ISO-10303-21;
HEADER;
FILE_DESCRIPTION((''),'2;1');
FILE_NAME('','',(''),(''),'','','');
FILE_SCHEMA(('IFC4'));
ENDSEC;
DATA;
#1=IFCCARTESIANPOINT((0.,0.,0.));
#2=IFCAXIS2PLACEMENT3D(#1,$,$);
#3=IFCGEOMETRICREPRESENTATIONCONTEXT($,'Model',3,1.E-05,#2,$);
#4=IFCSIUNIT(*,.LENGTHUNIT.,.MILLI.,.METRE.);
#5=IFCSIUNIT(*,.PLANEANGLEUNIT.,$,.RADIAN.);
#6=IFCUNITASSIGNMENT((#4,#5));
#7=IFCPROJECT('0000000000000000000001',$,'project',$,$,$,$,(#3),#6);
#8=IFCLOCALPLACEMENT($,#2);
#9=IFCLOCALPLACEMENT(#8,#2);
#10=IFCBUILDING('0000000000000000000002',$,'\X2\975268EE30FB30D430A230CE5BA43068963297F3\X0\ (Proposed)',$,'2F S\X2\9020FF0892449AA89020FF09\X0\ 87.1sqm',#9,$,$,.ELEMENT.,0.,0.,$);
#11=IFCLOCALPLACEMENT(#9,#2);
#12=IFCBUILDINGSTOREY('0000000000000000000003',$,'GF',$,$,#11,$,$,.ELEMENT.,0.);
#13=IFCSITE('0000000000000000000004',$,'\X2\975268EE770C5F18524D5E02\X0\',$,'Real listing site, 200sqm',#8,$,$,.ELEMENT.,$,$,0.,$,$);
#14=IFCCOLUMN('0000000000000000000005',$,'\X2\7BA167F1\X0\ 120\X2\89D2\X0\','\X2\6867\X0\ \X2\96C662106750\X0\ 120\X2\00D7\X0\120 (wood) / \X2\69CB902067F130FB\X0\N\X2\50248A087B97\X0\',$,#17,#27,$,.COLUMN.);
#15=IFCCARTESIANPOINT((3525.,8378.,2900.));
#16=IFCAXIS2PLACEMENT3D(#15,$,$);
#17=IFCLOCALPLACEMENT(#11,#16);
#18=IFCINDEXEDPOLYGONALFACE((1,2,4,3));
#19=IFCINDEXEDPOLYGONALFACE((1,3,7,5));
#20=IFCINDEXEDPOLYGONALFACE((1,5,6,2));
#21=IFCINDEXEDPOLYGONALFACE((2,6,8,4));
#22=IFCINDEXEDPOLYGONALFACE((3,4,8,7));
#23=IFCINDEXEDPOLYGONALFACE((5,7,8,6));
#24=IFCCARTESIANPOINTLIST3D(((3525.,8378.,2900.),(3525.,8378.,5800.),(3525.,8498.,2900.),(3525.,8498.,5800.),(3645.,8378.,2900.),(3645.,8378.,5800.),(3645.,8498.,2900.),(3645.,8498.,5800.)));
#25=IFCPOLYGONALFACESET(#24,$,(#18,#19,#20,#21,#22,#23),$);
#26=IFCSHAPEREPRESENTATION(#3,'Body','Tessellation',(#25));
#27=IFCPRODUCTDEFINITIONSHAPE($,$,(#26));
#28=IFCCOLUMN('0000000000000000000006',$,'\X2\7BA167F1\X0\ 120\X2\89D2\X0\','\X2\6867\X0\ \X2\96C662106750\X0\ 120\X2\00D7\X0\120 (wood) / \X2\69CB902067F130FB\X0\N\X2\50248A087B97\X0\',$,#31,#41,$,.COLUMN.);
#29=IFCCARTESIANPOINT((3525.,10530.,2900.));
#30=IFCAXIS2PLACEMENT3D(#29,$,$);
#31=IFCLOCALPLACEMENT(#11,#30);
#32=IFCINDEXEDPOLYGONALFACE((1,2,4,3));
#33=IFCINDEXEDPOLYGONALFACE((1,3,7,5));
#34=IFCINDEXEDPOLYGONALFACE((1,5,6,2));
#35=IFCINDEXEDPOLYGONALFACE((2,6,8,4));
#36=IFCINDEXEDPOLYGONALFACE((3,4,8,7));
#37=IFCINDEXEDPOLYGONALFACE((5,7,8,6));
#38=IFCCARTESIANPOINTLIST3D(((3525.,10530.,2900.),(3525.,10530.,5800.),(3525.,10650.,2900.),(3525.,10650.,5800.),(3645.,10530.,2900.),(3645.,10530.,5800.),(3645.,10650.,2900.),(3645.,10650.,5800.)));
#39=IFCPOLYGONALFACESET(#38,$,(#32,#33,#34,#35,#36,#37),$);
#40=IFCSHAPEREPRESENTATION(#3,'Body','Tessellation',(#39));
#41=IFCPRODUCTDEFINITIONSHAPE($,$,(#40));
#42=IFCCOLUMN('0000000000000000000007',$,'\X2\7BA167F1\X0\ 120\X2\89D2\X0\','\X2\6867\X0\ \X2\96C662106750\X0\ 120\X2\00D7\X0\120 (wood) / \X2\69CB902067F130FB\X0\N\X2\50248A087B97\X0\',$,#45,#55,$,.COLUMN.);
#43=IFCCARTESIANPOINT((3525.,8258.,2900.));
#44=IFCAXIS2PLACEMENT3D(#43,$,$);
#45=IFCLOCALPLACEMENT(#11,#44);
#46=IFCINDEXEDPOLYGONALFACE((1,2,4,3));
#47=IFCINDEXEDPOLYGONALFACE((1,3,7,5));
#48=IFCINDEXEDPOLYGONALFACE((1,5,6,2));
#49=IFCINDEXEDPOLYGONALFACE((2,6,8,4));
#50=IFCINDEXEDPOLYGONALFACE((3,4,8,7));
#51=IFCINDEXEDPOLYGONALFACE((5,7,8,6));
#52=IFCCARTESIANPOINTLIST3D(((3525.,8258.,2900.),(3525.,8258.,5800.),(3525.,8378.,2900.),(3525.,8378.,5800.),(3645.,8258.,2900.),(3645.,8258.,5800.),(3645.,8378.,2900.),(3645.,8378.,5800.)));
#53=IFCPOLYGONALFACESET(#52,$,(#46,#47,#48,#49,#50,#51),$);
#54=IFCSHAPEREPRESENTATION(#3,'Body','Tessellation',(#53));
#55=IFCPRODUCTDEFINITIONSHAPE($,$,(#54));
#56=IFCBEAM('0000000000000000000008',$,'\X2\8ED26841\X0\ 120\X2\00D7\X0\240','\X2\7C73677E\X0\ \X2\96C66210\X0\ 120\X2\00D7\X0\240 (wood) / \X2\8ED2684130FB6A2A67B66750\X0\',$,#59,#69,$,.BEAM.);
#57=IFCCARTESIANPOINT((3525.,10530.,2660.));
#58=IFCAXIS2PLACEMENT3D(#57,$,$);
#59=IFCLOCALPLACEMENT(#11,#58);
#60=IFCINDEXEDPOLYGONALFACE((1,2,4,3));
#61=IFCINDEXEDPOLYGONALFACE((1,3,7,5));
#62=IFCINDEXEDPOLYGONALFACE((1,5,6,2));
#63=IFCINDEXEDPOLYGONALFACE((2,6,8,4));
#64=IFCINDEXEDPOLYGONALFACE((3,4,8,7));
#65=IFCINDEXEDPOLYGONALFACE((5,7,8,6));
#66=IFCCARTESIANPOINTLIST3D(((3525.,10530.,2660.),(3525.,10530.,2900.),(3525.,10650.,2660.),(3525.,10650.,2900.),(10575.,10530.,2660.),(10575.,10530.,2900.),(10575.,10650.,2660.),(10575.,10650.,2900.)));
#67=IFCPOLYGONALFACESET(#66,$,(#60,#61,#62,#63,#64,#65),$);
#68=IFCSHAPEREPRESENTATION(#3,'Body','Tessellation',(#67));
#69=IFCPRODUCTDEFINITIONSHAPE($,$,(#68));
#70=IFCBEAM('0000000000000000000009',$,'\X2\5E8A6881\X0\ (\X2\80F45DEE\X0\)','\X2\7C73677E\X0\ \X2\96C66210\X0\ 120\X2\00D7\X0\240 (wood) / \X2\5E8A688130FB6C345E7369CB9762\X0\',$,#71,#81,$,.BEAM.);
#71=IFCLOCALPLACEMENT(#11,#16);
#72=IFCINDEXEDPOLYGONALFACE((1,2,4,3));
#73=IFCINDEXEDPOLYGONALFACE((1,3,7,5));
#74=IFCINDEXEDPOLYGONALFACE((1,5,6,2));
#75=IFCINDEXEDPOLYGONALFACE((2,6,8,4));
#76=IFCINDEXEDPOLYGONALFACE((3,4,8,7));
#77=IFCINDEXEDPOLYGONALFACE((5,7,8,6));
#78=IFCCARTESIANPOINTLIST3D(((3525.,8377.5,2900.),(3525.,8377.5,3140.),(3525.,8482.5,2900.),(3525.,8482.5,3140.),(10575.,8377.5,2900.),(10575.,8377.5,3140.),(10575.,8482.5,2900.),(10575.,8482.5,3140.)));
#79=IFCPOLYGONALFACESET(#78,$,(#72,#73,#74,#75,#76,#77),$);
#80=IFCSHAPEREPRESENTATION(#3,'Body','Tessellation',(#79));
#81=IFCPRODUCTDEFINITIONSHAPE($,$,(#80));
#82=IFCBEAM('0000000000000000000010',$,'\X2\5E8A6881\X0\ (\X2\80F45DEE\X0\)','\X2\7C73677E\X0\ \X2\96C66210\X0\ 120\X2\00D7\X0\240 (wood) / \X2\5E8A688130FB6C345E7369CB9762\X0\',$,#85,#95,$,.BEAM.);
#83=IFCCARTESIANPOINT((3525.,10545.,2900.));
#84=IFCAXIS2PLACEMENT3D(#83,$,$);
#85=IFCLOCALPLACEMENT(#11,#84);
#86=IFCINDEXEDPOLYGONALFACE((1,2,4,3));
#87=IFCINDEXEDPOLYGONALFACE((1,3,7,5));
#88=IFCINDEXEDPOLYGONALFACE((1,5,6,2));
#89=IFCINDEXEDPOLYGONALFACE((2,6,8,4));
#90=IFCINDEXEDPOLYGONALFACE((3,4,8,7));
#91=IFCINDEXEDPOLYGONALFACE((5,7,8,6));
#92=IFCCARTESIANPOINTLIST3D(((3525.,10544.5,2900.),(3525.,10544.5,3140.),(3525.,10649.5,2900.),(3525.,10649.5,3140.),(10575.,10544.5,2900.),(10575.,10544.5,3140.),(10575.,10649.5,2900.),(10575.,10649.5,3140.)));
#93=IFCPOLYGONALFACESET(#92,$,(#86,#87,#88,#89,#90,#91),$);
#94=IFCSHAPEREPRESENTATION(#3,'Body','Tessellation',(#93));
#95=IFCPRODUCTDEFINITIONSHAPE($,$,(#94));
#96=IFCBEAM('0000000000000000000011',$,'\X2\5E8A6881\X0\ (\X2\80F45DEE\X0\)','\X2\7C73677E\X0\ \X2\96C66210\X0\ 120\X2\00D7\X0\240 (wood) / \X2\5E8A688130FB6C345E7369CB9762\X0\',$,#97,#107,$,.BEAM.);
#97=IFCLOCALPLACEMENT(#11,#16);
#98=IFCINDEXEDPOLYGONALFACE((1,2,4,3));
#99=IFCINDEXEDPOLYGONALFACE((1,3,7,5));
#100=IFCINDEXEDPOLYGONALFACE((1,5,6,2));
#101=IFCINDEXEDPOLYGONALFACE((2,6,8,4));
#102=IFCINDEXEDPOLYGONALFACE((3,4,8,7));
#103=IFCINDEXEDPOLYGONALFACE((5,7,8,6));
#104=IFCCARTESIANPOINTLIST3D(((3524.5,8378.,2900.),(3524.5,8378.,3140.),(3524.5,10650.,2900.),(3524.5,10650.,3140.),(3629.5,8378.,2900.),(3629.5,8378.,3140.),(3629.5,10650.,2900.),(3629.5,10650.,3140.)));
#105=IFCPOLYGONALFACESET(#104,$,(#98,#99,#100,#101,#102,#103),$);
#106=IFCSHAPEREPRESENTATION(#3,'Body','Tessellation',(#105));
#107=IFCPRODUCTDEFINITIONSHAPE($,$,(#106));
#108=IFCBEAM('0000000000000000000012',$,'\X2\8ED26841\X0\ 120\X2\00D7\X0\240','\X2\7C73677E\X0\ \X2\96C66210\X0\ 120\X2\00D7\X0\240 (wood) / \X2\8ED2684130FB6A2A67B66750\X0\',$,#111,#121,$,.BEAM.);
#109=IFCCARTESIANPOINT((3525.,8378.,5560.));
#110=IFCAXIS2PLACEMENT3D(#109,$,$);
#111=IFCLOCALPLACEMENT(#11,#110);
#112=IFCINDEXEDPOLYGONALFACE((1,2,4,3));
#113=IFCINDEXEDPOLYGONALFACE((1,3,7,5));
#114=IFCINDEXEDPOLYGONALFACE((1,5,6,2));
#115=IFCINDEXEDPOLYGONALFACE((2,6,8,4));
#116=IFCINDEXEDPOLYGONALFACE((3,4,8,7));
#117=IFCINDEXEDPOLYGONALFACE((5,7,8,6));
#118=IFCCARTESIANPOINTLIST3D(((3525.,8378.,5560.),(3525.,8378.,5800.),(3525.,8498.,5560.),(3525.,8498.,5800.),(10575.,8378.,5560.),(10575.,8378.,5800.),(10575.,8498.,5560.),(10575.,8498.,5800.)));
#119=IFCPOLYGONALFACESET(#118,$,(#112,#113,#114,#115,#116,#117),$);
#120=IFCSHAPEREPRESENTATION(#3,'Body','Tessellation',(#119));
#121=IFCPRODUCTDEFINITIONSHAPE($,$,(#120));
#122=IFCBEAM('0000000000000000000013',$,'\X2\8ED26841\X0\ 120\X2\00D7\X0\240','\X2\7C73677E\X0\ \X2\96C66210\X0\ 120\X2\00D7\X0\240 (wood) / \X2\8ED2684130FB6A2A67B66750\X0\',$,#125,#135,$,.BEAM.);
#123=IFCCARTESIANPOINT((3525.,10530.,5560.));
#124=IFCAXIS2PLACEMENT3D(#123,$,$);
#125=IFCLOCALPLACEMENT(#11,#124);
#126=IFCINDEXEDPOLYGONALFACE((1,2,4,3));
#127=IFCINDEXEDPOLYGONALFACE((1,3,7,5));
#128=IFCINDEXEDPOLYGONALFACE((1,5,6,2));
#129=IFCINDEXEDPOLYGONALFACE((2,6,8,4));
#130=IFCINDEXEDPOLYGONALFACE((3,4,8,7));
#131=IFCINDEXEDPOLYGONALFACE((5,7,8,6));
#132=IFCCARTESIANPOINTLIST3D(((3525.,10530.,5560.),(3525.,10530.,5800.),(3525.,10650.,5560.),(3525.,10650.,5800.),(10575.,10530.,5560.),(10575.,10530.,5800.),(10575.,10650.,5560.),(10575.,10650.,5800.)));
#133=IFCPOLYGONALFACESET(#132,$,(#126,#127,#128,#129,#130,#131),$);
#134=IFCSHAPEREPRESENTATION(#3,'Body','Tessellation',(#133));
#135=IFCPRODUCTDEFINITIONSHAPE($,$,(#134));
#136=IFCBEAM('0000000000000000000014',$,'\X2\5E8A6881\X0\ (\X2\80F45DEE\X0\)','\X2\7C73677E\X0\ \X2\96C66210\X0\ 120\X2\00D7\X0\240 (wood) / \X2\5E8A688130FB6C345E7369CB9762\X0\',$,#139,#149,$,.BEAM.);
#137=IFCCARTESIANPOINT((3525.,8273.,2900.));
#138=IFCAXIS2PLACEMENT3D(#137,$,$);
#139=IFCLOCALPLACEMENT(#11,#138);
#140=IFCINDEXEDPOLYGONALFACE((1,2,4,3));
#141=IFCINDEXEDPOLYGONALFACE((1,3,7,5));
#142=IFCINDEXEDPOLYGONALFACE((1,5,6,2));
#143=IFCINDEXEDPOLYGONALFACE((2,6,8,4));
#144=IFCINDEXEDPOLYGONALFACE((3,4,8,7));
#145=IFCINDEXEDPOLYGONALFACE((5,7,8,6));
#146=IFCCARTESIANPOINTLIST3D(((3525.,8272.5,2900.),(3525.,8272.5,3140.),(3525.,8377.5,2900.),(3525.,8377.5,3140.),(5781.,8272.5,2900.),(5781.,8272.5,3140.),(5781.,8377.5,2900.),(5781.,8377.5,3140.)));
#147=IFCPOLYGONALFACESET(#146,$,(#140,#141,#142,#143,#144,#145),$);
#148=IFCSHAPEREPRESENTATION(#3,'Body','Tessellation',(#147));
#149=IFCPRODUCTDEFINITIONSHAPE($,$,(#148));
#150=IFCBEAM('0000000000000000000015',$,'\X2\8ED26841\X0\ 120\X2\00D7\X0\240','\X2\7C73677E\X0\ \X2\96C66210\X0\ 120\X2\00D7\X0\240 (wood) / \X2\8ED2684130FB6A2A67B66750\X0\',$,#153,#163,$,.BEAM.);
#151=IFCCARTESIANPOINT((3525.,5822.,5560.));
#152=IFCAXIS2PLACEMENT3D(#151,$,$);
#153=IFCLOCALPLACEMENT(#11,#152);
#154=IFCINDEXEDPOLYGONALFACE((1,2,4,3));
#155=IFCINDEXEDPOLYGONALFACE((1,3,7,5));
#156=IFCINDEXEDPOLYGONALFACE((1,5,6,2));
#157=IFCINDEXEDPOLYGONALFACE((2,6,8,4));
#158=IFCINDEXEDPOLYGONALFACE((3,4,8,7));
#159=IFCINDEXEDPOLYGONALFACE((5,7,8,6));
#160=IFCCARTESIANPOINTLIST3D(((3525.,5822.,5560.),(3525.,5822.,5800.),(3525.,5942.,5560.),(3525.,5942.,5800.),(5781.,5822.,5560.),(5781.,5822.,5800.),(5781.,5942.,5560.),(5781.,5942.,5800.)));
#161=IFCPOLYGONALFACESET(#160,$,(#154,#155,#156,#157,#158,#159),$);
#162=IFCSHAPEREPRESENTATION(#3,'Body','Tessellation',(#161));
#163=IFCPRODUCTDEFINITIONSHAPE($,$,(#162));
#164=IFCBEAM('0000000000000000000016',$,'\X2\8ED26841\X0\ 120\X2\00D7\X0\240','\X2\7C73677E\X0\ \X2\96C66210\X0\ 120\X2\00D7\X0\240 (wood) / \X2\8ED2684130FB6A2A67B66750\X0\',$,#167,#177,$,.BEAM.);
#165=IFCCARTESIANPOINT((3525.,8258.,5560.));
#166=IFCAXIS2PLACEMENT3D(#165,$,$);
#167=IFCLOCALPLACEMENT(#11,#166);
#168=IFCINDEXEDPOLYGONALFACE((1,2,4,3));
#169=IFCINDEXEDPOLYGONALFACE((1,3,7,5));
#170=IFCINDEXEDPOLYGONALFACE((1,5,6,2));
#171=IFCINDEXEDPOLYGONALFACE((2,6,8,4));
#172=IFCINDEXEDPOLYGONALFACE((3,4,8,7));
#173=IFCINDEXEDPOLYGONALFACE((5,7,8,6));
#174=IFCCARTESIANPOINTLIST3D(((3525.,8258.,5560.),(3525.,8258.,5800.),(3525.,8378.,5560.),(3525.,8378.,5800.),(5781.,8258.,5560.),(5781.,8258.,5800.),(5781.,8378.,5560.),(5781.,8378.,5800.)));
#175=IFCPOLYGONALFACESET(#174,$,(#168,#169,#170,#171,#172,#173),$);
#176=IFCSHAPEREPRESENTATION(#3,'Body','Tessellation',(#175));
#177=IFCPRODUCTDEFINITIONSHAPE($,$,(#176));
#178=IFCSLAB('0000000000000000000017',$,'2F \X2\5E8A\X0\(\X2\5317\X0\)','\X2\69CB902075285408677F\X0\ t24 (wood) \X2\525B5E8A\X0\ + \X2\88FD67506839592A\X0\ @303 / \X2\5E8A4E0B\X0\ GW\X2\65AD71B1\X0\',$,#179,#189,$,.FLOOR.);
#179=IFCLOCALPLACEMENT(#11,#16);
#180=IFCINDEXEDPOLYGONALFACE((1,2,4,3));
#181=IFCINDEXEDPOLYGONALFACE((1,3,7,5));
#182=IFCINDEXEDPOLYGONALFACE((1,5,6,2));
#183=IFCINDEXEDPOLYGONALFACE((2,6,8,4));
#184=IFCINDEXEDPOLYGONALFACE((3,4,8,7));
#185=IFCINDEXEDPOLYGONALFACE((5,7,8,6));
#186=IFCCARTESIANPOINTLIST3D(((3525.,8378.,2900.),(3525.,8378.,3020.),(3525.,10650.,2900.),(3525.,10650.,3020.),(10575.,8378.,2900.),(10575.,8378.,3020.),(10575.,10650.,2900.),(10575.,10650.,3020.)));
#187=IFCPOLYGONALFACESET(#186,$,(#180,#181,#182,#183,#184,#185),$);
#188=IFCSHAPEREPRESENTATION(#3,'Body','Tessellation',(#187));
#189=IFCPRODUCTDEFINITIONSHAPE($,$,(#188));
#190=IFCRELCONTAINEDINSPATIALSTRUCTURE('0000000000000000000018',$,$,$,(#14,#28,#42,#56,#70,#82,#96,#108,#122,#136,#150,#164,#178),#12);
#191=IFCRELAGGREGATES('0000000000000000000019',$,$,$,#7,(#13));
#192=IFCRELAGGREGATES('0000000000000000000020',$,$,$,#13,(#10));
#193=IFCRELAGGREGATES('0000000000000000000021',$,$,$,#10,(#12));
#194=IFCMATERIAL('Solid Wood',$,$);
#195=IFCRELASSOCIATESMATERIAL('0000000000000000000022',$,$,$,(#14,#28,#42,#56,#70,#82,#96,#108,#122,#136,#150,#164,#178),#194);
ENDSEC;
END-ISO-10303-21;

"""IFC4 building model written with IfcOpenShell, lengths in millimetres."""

from ifc_helpers import new_model, si_unit, frame, frame_2d, origin, place, context, project, spatial, rectangle, extrude, material, element, save


model = new_model("IFC4")

# Units and contexts
model_context = context("Model", 3, precision=1e-05, world=origin())
ifc_project = project(units=[si_unit("LENGTHUNIT", "METRE", prefix="MILLI"), si_unit("PLANEANGLEUNIT", "RADIAN")], contexts=[model_context])

# Site, building, storey
site_placement = place(None, origin())
site = spatial("IfcSite", under=ifc_project, at=site_placement, Name="青森県弘前市", ObjectType="Real listing site, 200sqm", CompositionType="ELEMENT", RefElevation=0.0)
building_placement = place(site_placement, origin())
building = spatial("IfcBuilding", under=site, at=building_placement, Name="青森・ピアノ室と防音 (Proposed)", ObjectType="2F S造（鉄骨造） 87.1sqm", CompositionType="ELEMENT", ElevationOfRefHeight=0.0, ElevationOfTerrain=0.0)
storey_placement = place(building_placement, origin())
storey = spatial("IfcBuildingStorey", under=building, at=storey_placement, Name="GF", CompositionType="ELEMENT", Elevation=0.0)

# Columns
ifc_material_1 = material(Name="Solid Wood")
column_1_placement = place(storey_placement, frame((3525.0, 8378.0, 2900.0)))
element("IfcColumn", 1, at=column_1_placement, inside=storey, material=ifc_material_1, Name="管柱 120角", Description="桧 集成材 120×120 (wood) / 構造柱・N値計算", PredefinedType="COLUMN", context=model_context, shape_type="SweptSolid", body=[
    extrude(rectangle(XDim=120.0, YDim=120.0, at=frame_2d((60.0, 60.0))), frame((3525.0, 8378.0, 2900.0)), (0.0, 0.0, 1.0), 2900.0),
])
column_2_placement = place(storey_placement, frame((3525.0, 10530.0, 2900.0)))
element("IfcColumn", 2, at=column_2_placement, inside=storey, material=ifc_material_1, Name="管柱 120角", Description="桧 集成材 120×120 (wood) / 構造柱・N値計算", PredefinedType="COLUMN", context=model_context, shape_type="SweptSolid", body=[
    extrude(rectangle(XDim=120.0, YDim=120.0, at=frame_2d((60.0, 60.0))), frame((3525.0, 10530.0, 2900.0)), (0.0, 0.0, 1.0), 2900.0),
])
column_3_placement = place(storey_placement, frame((3525.0, 8258.0, 2900.0)))
element("IfcColumn", 3, at=column_3_placement, inside=storey, material=ifc_material_1, Name="管柱 120角", Description="桧 集成材 120×120 (wood) / 構造柱・N値計算", PredefinedType="COLUMN", context=model_context, shape_type="SweptSolid", body=[
    extrude(rectangle(XDim=120.0, YDim=120.0, at=frame_2d((60.0, 60.0))), frame((3525.0, 8258.0, 2900.0)), (0.0, 0.0, 1.0), 2900.0),
])

# Beams
beam_1_placement = place(storey_placement, frame((3525.0, 10530.0, 2660.0)))
element("IfcBeam", 4, at=beam_1_placement, inside=storey, material=ifc_material_1, Name="軒桁 120×240", Description="米松 集成 120×240 (wood) / 軒桁・横架材", PredefinedType="BEAM", context=model_context, shape_type="SweptSolid", body=[
    extrude(rectangle(XDim=7050.0, YDim=120.0, at=frame_2d((3525.0, 60.0))), frame((3525.0, 10530.0, 2660.0)), (0.0, 0.0, 1.0), 240.0),
])
beam_2_placement = place(storey_placement, frame((3525.0, 8378.0, 2900.0)))
element("IfcBeam", 5, at=beam_2_placement, inside=storey, material=ifc_material_1, Name="床梁 (胴差)", Description="米松 集成 120×240 (wood) / 床梁・水平構面", PredefinedType="BEAM", context=model_context, shape_type="SweptSolid", body=[
    extrude(rectangle(XDim=7050.0, YDim=105.0, at=frame_2d((3525.0, 52.0))), frame((3525.0, 8378.0, 2900.0)), (0.0, 0.0, 1.0), 240.0),
])
beam_3_placement = place(storey_placement, frame((3525.0, 10545.0, 2900.0)))
element("IfcBeam", 6, at=beam_3_placement, inside=storey, material=ifc_material_1, Name="床梁 (胴差)", Description="米松 集成 120×240 (wood) / 床梁・水平構面", PredefinedType="BEAM", context=model_context, shape_type="SweptSolid", body=[
    extrude(rectangle(XDim=7050.0, YDim=105.0, at=frame_2d((3525.0, 52.0))), frame((3525.0, 10545.0, 2900.0)), (0.0, 0.0, 1.0), 240.0),
])
beam_4_placement = place(storey_placement, frame((3525.0, 8378.0, 2900.0)))
element("IfcBeam", 7, at=beam_4_placement, inside=storey, material=ifc_material_1, Name="床梁 (胴差)", Description="米松 集成 120×240 (wood) / 床梁・水平構面", PredefinedType="BEAM", context=model_context, shape_type="SweptSolid", body=[
    extrude(rectangle(XDim=105.0, YDim=2272.0, at=frame_2d((52.0, 1136.0))), frame((3525.0, 8378.0, 2900.0)), (0.0, 0.0, 1.0), 240.0),
])
beam_5_placement = place(storey_placement, frame((3525.0, 8378.0, 5560.0)))
element("IfcBeam", 8, at=beam_5_placement, inside=storey, material=ifc_material_1, Name="軒桁 120×240", Description="米松 集成 120×240 (wood) / 軒桁・横架材", PredefinedType="BEAM", context=model_context, shape_type="SweptSolid", body=[
    extrude(rectangle(XDim=7050.0, YDim=120.0, at=frame_2d((3525.0, 60.0))), frame((3525.0, 8378.0, 5560.0)), (0.0, 0.0, 1.0), 240.0),
])
beam_6_placement = place(storey_placement, frame((3525.0, 10530.0, 5560.0)))
element("IfcBeam", 9, at=beam_6_placement, inside=storey, material=ifc_material_1, Name="軒桁 120×240", Description="米松 集成 120×240 (wood) / 軒桁・横架材", PredefinedType="BEAM", context=model_context, shape_type="SweptSolid", body=[
    extrude(rectangle(XDim=7050.0, YDim=120.0, at=frame_2d((3525.0, 60.0))), frame((3525.0, 10530.0, 5560.0)), (0.0, 0.0, 1.0), 240.0),
])
beam_7_placement = place(storey_placement, frame((3525.0, 8273.0, 2900.0)))
element("IfcBeam", 10, at=beam_7_placement, inside=storey, material=ifc_material_1, Name="床梁 (胴差)", Description="米松 集成 120×240 (wood) / 床梁・水平構面", PredefinedType="BEAM", context=model_context, shape_type="SweptSolid", body=[
    extrude(rectangle(XDim=2256.0, YDim=105.0, at=frame_2d((1128.0, 52.0))), frame((3525.0, 8273.0, 2900.0)), (0.0, 0.0, 1.0), 240.0),
])
beam_8_placement = place(storey_placement, frame((3525.0, 5822.0, 5560.0)))
element("IfcBeam", 11, at=beam_8_placement, inside=storey, material=ifc_material_1, Name="軒桁 120×240", Description="米松 集成 120×240 (wood) / 軒桁・横架材", PredefinedType="BEAM", context=model_context, shape_type="SweptSolid", body=[
    extrude(rectangle(XDim=2256.0, YDim=120.0, at=frame_2d((1128.0, 60.0))), frame((3525.0, 5822.0, 5560.0)), (0.0, 0.0, 1.0), 240.0),
])
beam_9_placement = place(storey_placement, frame((3525.0, 8258.0, 5560.0)))
element("IfcBeam", 12, at=beam_9_placement, inside=storey, material=ifc_material_1, Name="軒桁 120×240", Description="米松 集成 120×240 (wood) / 軒桁・横架材", PredefinedType="BEAM", context=model_context, shape_type="SweptSolid", body=[
    extrude(rectangle(XDim=2256.0, YDim=120.0, at=frame_2d((1128.0, 60.0))), frame((3525.0, 8258.0, 5560.0)), (0.0, 0.0, 1.0), 240.0),
])

# Slab
slab_placement = place(storey_placement, frame((3525.0, 8378.0, 2900.0)))
element("IfcSlab", 13, at=slab_placement, inside=storey, material=ifc_material_1, Name="2F 床(北)", Description="構造用合板 t24 (wood) 剛床 + 製材根太 @303 / 床下 GW断熱", PredefinedType="FLOOR", context=model_context, shape_type="SweptSolid", body=[
    extrude(rectangle(XDim=7050.0, YDim=2272.0, at=frame_2d((3525.0, 1136.0))), frame((3525.0, 8378.0, 2900.0)), (0.0, 0.0, 1.0), 120.0),
])

save(model, "model.ifc")
